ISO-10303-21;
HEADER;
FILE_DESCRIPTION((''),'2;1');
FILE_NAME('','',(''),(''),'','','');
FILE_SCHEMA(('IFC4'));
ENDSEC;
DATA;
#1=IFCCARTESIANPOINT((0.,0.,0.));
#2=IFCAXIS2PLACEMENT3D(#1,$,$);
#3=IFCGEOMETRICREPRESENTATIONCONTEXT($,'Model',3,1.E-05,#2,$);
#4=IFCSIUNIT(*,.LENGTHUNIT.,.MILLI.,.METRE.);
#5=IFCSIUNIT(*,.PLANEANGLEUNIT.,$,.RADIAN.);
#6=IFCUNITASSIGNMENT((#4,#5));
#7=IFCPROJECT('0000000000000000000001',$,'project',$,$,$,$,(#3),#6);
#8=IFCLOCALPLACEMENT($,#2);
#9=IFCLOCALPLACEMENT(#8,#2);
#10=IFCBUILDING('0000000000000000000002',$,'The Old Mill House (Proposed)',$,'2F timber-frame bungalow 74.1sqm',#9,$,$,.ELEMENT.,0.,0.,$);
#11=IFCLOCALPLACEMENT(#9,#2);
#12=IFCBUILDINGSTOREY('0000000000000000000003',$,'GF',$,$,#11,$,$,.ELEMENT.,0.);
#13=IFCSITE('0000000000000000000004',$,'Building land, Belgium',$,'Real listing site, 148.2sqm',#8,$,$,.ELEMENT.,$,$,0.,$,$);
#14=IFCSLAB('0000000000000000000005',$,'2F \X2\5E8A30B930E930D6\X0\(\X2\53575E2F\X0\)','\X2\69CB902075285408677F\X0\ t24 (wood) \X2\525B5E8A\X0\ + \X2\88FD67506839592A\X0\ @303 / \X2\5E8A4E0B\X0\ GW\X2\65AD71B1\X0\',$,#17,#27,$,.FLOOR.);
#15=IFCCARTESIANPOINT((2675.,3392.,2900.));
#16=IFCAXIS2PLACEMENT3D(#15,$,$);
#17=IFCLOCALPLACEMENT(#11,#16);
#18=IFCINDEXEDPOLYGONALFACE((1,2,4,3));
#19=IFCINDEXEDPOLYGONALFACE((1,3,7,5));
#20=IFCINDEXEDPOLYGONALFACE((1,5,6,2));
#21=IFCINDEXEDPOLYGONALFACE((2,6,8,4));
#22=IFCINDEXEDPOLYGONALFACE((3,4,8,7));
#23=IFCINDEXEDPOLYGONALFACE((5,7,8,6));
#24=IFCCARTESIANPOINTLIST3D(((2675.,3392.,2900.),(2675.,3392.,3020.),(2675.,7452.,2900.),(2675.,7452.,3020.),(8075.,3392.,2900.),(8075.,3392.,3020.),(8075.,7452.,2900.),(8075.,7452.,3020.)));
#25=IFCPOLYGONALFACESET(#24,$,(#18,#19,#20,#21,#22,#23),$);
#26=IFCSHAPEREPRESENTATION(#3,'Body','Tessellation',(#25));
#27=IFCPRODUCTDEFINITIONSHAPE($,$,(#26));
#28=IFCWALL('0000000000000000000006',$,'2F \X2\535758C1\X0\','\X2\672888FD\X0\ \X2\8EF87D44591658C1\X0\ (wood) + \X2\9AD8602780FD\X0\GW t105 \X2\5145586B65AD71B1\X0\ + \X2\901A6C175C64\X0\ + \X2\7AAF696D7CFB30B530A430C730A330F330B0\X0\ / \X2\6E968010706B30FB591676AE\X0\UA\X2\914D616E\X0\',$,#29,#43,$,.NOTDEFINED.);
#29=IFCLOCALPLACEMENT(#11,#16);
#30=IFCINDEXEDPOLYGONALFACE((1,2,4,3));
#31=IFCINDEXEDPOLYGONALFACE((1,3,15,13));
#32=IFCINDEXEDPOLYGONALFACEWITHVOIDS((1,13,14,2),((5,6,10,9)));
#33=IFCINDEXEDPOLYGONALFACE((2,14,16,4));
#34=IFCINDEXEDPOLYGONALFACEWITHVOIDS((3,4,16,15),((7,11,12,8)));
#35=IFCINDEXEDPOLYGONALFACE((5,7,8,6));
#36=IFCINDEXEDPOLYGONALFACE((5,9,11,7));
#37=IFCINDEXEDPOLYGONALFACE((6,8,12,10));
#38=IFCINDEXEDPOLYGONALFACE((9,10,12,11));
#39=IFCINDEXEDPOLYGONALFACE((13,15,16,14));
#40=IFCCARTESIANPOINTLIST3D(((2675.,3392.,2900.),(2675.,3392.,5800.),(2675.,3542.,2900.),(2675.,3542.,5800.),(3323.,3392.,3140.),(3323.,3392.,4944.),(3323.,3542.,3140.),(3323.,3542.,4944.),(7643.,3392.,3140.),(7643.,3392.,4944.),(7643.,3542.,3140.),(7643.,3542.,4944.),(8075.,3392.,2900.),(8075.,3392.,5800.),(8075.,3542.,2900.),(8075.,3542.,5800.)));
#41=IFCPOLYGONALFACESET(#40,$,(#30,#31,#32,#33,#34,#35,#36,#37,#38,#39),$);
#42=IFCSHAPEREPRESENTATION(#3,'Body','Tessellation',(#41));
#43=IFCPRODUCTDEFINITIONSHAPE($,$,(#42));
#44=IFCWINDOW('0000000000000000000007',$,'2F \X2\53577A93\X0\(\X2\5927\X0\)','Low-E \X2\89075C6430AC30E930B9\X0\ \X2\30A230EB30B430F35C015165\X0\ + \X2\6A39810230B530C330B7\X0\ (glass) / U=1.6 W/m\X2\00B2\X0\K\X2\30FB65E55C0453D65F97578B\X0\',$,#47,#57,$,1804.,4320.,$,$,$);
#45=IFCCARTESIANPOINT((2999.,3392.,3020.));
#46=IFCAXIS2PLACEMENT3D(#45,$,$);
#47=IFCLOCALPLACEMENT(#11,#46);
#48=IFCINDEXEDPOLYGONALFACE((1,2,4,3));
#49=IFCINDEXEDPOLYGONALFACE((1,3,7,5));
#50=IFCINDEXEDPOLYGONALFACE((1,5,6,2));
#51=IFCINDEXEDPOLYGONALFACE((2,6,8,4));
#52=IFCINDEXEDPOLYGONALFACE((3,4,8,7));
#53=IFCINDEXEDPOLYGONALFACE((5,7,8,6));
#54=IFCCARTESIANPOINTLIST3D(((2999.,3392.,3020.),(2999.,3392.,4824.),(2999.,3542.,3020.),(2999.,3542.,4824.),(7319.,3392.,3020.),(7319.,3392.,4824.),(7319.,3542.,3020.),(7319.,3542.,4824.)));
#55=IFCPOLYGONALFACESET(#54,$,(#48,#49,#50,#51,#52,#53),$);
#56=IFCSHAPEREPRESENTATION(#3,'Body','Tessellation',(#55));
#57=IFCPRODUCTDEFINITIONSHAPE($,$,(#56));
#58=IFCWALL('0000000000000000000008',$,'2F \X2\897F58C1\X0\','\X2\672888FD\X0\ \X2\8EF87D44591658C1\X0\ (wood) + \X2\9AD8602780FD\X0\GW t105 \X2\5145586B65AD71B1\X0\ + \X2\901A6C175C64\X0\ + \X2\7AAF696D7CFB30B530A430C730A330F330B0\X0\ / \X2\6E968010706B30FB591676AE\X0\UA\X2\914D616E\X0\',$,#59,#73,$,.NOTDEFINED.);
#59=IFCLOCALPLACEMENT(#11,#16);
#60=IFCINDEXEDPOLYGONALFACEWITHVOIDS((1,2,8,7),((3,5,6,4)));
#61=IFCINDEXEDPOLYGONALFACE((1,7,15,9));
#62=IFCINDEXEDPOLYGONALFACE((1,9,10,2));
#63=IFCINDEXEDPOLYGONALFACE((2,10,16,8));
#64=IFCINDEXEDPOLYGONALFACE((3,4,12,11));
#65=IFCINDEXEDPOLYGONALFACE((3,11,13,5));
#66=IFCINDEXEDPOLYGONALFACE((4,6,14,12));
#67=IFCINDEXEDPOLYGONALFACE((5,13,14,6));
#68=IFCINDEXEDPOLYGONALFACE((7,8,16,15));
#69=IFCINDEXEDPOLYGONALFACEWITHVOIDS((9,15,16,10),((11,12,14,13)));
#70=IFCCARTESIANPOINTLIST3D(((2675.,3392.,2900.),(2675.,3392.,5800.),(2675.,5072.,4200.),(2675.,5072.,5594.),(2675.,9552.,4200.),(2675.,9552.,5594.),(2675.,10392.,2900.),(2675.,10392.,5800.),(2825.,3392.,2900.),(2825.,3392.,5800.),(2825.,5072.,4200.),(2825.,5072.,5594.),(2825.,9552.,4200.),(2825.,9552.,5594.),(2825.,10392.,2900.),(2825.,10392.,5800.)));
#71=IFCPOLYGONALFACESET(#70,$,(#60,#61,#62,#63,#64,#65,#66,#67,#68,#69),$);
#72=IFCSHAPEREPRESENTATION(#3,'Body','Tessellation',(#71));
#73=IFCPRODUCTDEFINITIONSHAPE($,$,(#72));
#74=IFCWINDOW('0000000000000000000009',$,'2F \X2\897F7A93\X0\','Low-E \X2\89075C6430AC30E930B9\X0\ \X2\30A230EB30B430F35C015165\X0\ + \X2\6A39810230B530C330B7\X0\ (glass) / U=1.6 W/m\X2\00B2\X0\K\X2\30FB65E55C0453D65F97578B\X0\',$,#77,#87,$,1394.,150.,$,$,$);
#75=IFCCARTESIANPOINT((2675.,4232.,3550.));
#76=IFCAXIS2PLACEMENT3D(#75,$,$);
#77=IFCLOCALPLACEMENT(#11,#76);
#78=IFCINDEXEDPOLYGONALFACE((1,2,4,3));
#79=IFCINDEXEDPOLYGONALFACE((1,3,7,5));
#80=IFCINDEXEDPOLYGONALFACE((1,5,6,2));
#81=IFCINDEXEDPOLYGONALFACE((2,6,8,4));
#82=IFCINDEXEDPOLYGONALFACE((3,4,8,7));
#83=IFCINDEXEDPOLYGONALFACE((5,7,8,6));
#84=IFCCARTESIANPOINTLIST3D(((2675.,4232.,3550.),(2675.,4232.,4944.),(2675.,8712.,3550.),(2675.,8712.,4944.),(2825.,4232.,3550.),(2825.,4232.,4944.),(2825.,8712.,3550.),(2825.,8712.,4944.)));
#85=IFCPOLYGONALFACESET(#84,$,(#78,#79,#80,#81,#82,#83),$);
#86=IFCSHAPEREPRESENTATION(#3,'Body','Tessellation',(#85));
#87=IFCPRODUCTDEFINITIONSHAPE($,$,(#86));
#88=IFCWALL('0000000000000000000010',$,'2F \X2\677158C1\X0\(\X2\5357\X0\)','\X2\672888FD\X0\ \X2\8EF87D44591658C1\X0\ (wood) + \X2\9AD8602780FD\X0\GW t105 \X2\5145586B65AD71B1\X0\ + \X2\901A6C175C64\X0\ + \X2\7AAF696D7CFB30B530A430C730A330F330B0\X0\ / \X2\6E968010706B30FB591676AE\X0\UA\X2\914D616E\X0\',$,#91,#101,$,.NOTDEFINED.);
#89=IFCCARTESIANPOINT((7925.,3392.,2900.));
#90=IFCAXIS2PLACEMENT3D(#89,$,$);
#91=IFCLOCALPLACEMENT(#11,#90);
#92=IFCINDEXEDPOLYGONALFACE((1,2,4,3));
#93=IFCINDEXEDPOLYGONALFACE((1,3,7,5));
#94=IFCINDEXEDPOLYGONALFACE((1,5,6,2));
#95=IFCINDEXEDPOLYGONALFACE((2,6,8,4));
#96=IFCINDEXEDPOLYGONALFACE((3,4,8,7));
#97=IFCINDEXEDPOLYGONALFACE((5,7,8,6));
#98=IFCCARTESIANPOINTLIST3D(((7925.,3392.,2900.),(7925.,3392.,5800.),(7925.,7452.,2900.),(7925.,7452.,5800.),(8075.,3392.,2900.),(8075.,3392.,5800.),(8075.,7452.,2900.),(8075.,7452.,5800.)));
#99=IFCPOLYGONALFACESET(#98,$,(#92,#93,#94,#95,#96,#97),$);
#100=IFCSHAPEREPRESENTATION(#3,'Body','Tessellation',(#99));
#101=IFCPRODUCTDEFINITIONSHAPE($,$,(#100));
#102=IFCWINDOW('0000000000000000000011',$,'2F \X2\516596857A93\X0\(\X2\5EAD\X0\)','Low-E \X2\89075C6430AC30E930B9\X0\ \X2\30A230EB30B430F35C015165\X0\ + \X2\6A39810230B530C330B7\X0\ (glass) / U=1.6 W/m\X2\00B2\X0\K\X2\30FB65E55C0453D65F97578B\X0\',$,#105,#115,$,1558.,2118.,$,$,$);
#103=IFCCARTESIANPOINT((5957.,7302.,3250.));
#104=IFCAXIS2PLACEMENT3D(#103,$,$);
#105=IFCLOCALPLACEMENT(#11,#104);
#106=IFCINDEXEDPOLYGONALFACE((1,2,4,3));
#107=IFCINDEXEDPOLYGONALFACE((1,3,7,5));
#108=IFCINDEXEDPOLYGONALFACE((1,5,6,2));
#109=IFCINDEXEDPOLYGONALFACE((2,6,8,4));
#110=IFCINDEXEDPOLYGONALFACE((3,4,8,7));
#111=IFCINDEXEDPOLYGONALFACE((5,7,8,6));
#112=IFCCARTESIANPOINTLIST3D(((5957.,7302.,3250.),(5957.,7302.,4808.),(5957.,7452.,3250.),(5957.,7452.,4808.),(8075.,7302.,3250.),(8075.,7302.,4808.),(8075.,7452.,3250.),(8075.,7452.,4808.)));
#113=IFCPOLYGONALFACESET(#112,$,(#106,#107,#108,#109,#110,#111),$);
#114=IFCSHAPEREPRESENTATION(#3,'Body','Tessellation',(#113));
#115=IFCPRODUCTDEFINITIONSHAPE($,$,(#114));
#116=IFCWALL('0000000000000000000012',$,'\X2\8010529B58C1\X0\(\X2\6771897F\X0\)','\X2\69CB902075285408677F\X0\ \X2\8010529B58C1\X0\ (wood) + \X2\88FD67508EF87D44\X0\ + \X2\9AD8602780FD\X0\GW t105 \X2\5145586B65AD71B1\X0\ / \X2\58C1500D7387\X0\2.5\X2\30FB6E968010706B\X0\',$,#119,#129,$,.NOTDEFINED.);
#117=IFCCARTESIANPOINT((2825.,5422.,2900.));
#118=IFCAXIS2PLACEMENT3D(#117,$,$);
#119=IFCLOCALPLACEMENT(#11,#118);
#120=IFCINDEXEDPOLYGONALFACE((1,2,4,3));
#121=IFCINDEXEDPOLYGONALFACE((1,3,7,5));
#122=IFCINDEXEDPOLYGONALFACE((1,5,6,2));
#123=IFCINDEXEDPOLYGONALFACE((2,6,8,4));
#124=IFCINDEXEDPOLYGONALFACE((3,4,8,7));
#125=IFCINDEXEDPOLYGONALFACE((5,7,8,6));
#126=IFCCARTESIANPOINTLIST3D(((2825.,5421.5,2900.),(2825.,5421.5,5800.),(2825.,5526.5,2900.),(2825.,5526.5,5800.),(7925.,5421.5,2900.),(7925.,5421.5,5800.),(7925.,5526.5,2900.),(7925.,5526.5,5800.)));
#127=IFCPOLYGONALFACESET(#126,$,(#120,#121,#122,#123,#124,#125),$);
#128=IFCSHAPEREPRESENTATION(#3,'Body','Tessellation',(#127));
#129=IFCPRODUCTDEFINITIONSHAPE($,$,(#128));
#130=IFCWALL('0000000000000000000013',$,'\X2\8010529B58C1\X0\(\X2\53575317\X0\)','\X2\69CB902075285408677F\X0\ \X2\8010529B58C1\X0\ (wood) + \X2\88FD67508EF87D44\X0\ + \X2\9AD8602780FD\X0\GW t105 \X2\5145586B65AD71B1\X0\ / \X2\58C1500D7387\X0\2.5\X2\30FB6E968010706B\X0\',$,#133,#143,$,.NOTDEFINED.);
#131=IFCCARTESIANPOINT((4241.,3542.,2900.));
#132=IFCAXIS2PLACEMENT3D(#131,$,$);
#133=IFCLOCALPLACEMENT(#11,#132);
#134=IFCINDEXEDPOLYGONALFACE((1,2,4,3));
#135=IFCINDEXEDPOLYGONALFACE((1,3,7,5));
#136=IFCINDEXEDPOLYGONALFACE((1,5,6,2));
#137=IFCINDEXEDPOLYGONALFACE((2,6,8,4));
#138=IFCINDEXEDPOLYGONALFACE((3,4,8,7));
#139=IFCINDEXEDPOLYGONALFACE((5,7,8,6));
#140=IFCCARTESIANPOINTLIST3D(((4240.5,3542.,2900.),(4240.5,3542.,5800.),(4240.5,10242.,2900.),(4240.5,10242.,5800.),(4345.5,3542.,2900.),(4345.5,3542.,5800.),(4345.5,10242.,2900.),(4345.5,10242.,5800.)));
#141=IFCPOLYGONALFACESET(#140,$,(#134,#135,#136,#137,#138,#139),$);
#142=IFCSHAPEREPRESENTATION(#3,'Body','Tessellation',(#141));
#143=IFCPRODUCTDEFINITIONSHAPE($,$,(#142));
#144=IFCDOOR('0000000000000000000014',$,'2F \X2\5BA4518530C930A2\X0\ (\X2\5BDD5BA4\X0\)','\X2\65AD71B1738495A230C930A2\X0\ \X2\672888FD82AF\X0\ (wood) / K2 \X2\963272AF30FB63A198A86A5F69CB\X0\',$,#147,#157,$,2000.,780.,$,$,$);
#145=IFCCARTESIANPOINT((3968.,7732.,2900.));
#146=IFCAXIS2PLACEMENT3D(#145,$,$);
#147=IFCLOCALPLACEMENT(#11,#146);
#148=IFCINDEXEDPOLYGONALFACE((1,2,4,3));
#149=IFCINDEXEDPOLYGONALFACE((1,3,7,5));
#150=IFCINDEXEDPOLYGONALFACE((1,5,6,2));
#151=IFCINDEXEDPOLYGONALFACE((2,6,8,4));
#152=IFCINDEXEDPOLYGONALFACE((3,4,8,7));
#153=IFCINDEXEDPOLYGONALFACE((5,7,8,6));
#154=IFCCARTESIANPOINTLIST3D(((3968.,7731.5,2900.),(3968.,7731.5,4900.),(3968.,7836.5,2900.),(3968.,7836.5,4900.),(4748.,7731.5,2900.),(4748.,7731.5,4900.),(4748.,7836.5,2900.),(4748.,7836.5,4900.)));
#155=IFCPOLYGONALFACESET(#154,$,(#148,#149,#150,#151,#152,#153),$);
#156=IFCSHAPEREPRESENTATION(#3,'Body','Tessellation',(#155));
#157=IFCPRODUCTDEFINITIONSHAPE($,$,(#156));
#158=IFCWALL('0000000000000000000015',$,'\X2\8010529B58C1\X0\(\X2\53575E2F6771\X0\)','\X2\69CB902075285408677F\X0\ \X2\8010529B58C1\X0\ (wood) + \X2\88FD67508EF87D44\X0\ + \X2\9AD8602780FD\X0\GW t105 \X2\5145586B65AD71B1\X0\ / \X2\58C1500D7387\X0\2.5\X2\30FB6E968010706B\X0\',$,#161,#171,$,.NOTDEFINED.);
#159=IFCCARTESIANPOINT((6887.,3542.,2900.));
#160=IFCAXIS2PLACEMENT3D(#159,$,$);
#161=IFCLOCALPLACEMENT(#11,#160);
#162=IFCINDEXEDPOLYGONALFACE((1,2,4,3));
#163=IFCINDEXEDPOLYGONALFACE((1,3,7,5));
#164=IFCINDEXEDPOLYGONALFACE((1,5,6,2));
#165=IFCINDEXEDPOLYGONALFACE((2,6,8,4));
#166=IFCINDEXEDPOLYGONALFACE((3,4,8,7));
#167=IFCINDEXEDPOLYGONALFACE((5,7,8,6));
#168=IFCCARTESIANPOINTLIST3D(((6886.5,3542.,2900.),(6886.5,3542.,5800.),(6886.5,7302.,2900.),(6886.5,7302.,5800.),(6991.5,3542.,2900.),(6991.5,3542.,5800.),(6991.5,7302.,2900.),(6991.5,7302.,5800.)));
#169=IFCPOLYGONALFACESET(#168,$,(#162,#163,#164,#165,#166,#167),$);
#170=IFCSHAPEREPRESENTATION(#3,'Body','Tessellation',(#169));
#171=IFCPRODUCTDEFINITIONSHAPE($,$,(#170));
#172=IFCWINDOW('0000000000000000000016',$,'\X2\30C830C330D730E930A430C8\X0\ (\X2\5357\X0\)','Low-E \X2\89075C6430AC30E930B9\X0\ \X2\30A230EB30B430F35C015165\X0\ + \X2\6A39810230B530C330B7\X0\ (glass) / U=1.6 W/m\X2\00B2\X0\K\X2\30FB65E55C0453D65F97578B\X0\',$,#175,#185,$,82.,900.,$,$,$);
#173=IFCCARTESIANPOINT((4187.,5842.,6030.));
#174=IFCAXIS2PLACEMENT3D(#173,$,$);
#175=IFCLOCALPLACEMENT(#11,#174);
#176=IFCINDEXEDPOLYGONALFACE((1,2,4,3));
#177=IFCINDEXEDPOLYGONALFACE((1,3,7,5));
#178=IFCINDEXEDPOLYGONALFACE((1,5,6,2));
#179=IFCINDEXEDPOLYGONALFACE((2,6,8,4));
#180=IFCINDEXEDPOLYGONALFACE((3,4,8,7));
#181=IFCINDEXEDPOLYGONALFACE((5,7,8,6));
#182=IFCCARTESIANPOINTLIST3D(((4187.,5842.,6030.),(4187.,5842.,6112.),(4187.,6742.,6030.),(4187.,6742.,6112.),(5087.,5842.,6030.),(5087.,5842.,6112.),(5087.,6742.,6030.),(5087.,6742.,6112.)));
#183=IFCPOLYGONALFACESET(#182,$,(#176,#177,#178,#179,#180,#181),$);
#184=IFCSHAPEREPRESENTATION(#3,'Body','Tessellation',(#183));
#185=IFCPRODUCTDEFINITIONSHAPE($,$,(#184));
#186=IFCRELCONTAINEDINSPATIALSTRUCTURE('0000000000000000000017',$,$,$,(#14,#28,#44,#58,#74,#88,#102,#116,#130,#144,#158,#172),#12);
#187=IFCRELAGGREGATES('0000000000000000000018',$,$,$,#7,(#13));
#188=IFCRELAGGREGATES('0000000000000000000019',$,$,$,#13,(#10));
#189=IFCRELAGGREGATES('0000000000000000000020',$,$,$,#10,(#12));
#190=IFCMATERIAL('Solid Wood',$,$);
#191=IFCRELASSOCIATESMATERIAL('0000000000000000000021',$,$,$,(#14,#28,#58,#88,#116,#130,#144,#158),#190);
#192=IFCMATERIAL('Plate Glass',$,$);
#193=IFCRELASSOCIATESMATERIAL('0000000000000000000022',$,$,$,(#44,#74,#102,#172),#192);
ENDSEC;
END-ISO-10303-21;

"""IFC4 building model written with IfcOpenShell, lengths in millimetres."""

from ifc_helpers import new_model, si_unit, frame, frame_2d, origin, place, context, project, spatial, rectangle, extrude, material, element, fill, save


model = new_model("IFC4")

# Units and contexts
model_context = context("Model", 3, precision=1e-05, world=origin())
ifc_project = project(units=[si_unit("LENGTHUNIT", "METRE", prefix="MILLI"), si_unit("PLANEANGLEUNIT", "RADIAN")], contexts=[model_context])

# Site, building, storey
site_placement = place(None, origin())
site = spatial("IfcSite", under=ifc_project, at=site_placement, Name="Building land, Belgium", ObjectType="Real listing site, 148.2sqm", CompositionType="ELEMENT", RefElevation=0.0)
building_placement = place(site_placement, origin())
building = spatial("IfcBuilding", under=site, at=building_placement, Name="The Old Mill House (Proposed)", ObjectType="2F timber-frame bungalow 74.1sqm", CompositionType="ELEMENT", ElevationOfRefHeight=0.0, ElevationOfTerrain=0.0)
storey_placement = place(building_placement, origin())
storey = spatial("IfcBuildingStorey", under=building, at=storey_placement, Name="GF", CompositionType="ELEMENT", Elevation=0.0)

# Slab
ifc_material_1 = material(Name="Solid Wood")
slab_placement = place(storey_placement, frame((2675.0, 3392.0, 2900.0)))
element("IfcSlab", 1, at=slab_placement, inside=storey, material=ifc_material_1, Name="2F 床スラブ(南帯)", Description="構造用合板 t24 (wood) 剛床 + 製材根太 @303 / 床下 GW断熱", PredefinedType="FLOOR", context=model_context, shape_type="SweptSolid", body=[
    extrude(rectangle(XDim=5400.0, YDim=4060.0, at=frame_2d((2700.0, 2030.0))), frame((2675.0, 3392.0, 2900.0)), (0.0, 0.0, 1.0), 120.0),
])

# Walls, openings, windows
wall_1_placement = place(storey_placement, frame((2675.0, 3392.0, 2900.0)))
wall_1 = element("IfcWall", 2, at=wall_1_placement, inside=storey, material=ifc_material_1, Name="2F 南壁", Description="木製 軸組外壁 (wood) + 高性能GW t105 充填断熱 + 通気層 + 窯業系サイディング / 準耐火・外皮UA配慮", PredefinedType="NOTDEFINED", context=model_context, shape_type="SweptSolid", body=[
    extrude(rectangle(XDim=5400.0, YDim=150.0, at=frame_2d((2700.0, 75.0))), frame((2675.0, 3392.0, 2900.0)), (0.0, 0.0, 1.0), 2900.0),
])
opening_1_placement = place(storey_placement, frame((2999.0, 3392.0, 3020.0)))
opening_1 = element("IfcOpeningElement", 3, at=opening_1_placement, cuts=wall_1, PredefinedType="NOTDEFINED", context=model_context, shape_type="SweptSolid", body=[
    extrude(rectangle(XDim=4320.0, YDim=150.0, at=frame_2d((2160.0, 75.0))), frame((2999.0, 3392.0, 3020.0)), (0.0, 0.0, 1.0), 1804.0),
])
ifc_material_2 = material(Name="Plate Glass")
window_1_placement = place(storey_placement, frame((2999.0, 3392.0, 3020.0)))
window_1 = element("IfcWindow", 4, at=window_1_placement, inside=storey, material=ifc_material_2, Name="2F 南窓(大)", Description="Low-E 複層ガラス アルゴン封入 + 樹脂サッシ (glass) / U=1.6 W/m²K・日射取得型", OverallHeight=1804.0, OverallWidth=4320.0, context=model_context, shape_type="SweptSolid", body=[
    extrude(rectangle(XDim=4320.0, YDim=150.0, at=frame_2d((2160.0, 75.0))), frame((2999.0, 3392.0, 3020.0)), (0.0, 0.0, 1.0), 1804.0),
])
fill(opening_1, window_1)
wall_2_placement = place(storey_placement, frame((2675.0, 3392.0, 2900.0)))
wall_2 = element("IfcWall", 5, at=wall_2_placement, inside=storey, material=ifc_material_1, Name="2F 西壁", Description="木製 軸組外壁 (wood) + 高性能GW t105 充填断熱 + 通気層 + 窯業系サイディング / 準耐火・外皮UA配慮", PredefinedType="NOTDEFINED", context=model_context, shape_type="SweptSolid", body=[
    extrude(rectangle(XDim=150.0, YDim=7000.0, at=frame_2d((75.0, 3500.0))), frame((2675.0, 3392.0, 2900.0)), (0.0, 0.0, 1.0), 2900.0),
])
opening_2_placement = place(storey_placement, frame((2675.0, 4232.0, 3550.0)))
opening_2 = element("IfcOpeningElement", 6, at=opening_2_placement, cuts=wall_2, PredefinedType="NOTDEFINED", context=model_context, shape_type="SweptSolid", body=[
    extrude(rectangle(XDim=150.0, YDim=4480.0, at=frame_2d((75.0, 2240.0))), frame((2675.0, 4232.0, 3550.0)), (0.0, 0.0, 1.0), 1394.0),
])
window_2_placement = place(storey_placement, frame((2675.0, 4232.0, 3550.0)))
window_2 = element("IfcWindow", 7, at=window_2_placement, inside=storey, material=ifc_material_2, Name="2F 西窓", Description="Low-E 複層ガラス アルゴン封入 + 樹脂サッシ (glass) / U=1.6 W/m²K・日射取得型", OverallHeight=1394.0, OverallWidth=150.0, context=model_context, shape_type="SweptSolid", body=[
    extrude(rectangle(XDim=150.0, YDim=4480.0, at=frame_2d((75.0, 2240.0))), frame((2675.0, 4232.0, 3550.0)), (0.0, 0.0, 1.0), 1394.0),
])
fill(opening_2, window_2)
wall_3_placement = place(storey_placement, frame((7925.0, 3392.0, 2900.0)))
wall_3 = element("IfcWall", 8, at=wall_3_placement, inside=storey, material=ifc_material_1, Name="2F 東壁(南)", Description="木製 軸組外壁 (wood) + 高性能GW t105 充填断熱 + 通気層 + 窯業系サイディング / 準耐火・外皮UA配慮", PredefinedType="NOTDEFINED", context=model_context, shape_type="SweptSolid", body=[
    extrude(rectangle(XDim=150.0, YDim=4060.0, at=frame_2d((75.0, 2030.0))), frame((7925.0, 3392.0, 2900.0)), (0.0, 0.0, 1.0), 2900.0),
])
opening_3_placement = place(storey_placement, frame((5957.0, 7302.0, 3250.0)))
opening_3 = element("IfcOpeningElement", 9, at=opening_3_placement, cuts=wall_3, PredefinedType="NOTDEFINED", context=model_context, shape_type="SweptSolid", body=[
    extrude(rectangle(XDim=2118.0, YDim=150.0, at=frame_2d((1059.0, 75.0))), frame((5957.0, 7302.0, 3250.0)), (0.0, 0.0, 1.0), 1558.0),
])
window_3_placement = place(storey_placement, frame((5957.0, 7302.0, 3250.0)))
window_3 = element("IfcWindow", 10, at=window_3_placement, inside=storey, material=ifc_material_2, Name="2F 入隅窓(庭)", Description="Low-E 複層ガラス アルゴン封入 + 樹脂サッシ (glass) / U=1.6 W/m²K・日射取得型", OverallHeight=1558.0, OverallWidth=2118.0, context=model_context, shape_type="SweptSolid", body=[
    extrude(rectangle(XDim=2118.0, YDim=150.0, at=frame_2d((1059.0, 75.0))), frame((5957.0, 7302.0, 3250.0)), (0.0, 0.0, 1.0), 1558.0),
])
fill(opening_3, window_3)

# Wall
wall_4_placement = place(storey_placement, frame((2825.0, 5422.0, 2900.0)))
element("IfcWall", 11, at=wall_4_placement, inside=storey, material=ifc_material_1, Name="耐力壁(東西)", Description="構造用合板 耐力壁 (wood) + 製材軸組 + 高性能GW t105 充填断熱 / 壁倍率2.5・準耐火", PredefinedType="NOTDEFINED", context=model_context, shape_type="SweptSolid", body=[
    extrude(rectangle(XDim=5100.0, YDim=105.0, at=frame_2d((2550.0, 52.0))), frame((2825.0, 5422.0, 2900.0)), (0.0, 0.0, 1.0), 2900.0),
])

# Wall, opening, door
wall_5_placement = place(storey_placement, frame((4241.0, 3542.0, 2900.0)))
wall_5 = element("IfcWall", 12, at=wall_5_placement, inside=storey, material=ifc_material_1, Name="耐力壁(南北)", Description="構造用合板 耐力壁 (wood) + 製材軸組 + 高性能GW t105 充填断熱 / 壁倍率2.5・準耐火", PredefinedType="NOTDEFINED", context=model_context, shape_type="SweptSolid", body=[
    extrude(rectangle(XDim=105.0, YDim=6700.0, at=frame_2d((52.0, 3350.0))), frame((4241.0, 3542.0, 2900.0)), (0.0, 0.0, 1.0), 2900.0),
])
opening_4_placement = place(storey_placement, frame((3968.0, 7732.0, 2900.0)))
opening_4 = element("IfcOpeningElement", 13, at=opening_4_placement, cuts=wall_5, PredefinedType="NOTDEFINED", context=model_context, shape_type="SweptSolid", body=[
    extrude(rectangle(XDim=780.0, YDim=105.0, at=frame_2d((390.0, 52.0))), frame((3968.0, 7732.0, 2900.0)), (0.0, 0.0, 1.0), 2000.0),
])
door_placement = place(storey_placement, frame((3968.0, 7732.0, 2900.0)))
door = element("IfcDoor", 14, at=door_placement, inside=storey, material=ifc_material_1, Name="2F 室内ドア (寝室)", Description="断熱玄関ドア 木製芯 (wood) / K2 防犯・採風機構", OverallHeight=2000.0, OverallWidth=780.0, context=model_context, shape_type="SweptSolid", body=[
    extrude(rectangle(XDim=780.0, YDim=105.0, at=frame_2d((390.0, 52.0))), frame((3968.0, 7732.0, 2900.0)), (0.0, 0.0, 1.0), 2000.0),
])
fill(opening_4, door)

# Wall
wall_6_placement = place(storey_placement, frame((6887.0, 3542.0, 2900.0)))
element("IfcWall", 15, at=wall_6_placement, inside=storey, material=ifc_material_1, Name="耐力壁(南帯東)", Description="構造用合板 耐力壁 (wood) + 製材軸組 + 高性能GW t105 充填断熱 / 壁倍率2.5・準耐火", PredefinedType="NOTDEFINED", context=model_context, shape_type="SweptSolid", body=[
    extrude(rectangle(XDim=105.0, YDim=3760.0, at=frame_2d((52.0, 1880.0))), frame((6887.0, 3542.0, 2900.0)), (0.0, 0.0, 1.0), 2900.0),
])

# Window
window_4_placement = place(storey_placement, frame((4187.0, 5842.0, 6030.0)))
element("IfcWindow", 16, at=window_4_placement, inside=storey, material=ifc_material_2, Name="トップライト (南)", Description="Low-E 複層ガラス アルゴン封入 + 樹脂サッシ (glass) / U=1.6 W/m²K・日射取得型", OverallHeight=82.0, OverallWidth=900.0, context=model_context, shape_type="SweptSolid", body=[
    extrude(rectangle(XDim=900.0, YDim=900.0, at=frame_2d((450.0, 450.0))), frame((4187.0, 5842.0, 6030.0)), (0.0, 0.0, 1.0), 82.0),
])

save(model, "model.ifc")
